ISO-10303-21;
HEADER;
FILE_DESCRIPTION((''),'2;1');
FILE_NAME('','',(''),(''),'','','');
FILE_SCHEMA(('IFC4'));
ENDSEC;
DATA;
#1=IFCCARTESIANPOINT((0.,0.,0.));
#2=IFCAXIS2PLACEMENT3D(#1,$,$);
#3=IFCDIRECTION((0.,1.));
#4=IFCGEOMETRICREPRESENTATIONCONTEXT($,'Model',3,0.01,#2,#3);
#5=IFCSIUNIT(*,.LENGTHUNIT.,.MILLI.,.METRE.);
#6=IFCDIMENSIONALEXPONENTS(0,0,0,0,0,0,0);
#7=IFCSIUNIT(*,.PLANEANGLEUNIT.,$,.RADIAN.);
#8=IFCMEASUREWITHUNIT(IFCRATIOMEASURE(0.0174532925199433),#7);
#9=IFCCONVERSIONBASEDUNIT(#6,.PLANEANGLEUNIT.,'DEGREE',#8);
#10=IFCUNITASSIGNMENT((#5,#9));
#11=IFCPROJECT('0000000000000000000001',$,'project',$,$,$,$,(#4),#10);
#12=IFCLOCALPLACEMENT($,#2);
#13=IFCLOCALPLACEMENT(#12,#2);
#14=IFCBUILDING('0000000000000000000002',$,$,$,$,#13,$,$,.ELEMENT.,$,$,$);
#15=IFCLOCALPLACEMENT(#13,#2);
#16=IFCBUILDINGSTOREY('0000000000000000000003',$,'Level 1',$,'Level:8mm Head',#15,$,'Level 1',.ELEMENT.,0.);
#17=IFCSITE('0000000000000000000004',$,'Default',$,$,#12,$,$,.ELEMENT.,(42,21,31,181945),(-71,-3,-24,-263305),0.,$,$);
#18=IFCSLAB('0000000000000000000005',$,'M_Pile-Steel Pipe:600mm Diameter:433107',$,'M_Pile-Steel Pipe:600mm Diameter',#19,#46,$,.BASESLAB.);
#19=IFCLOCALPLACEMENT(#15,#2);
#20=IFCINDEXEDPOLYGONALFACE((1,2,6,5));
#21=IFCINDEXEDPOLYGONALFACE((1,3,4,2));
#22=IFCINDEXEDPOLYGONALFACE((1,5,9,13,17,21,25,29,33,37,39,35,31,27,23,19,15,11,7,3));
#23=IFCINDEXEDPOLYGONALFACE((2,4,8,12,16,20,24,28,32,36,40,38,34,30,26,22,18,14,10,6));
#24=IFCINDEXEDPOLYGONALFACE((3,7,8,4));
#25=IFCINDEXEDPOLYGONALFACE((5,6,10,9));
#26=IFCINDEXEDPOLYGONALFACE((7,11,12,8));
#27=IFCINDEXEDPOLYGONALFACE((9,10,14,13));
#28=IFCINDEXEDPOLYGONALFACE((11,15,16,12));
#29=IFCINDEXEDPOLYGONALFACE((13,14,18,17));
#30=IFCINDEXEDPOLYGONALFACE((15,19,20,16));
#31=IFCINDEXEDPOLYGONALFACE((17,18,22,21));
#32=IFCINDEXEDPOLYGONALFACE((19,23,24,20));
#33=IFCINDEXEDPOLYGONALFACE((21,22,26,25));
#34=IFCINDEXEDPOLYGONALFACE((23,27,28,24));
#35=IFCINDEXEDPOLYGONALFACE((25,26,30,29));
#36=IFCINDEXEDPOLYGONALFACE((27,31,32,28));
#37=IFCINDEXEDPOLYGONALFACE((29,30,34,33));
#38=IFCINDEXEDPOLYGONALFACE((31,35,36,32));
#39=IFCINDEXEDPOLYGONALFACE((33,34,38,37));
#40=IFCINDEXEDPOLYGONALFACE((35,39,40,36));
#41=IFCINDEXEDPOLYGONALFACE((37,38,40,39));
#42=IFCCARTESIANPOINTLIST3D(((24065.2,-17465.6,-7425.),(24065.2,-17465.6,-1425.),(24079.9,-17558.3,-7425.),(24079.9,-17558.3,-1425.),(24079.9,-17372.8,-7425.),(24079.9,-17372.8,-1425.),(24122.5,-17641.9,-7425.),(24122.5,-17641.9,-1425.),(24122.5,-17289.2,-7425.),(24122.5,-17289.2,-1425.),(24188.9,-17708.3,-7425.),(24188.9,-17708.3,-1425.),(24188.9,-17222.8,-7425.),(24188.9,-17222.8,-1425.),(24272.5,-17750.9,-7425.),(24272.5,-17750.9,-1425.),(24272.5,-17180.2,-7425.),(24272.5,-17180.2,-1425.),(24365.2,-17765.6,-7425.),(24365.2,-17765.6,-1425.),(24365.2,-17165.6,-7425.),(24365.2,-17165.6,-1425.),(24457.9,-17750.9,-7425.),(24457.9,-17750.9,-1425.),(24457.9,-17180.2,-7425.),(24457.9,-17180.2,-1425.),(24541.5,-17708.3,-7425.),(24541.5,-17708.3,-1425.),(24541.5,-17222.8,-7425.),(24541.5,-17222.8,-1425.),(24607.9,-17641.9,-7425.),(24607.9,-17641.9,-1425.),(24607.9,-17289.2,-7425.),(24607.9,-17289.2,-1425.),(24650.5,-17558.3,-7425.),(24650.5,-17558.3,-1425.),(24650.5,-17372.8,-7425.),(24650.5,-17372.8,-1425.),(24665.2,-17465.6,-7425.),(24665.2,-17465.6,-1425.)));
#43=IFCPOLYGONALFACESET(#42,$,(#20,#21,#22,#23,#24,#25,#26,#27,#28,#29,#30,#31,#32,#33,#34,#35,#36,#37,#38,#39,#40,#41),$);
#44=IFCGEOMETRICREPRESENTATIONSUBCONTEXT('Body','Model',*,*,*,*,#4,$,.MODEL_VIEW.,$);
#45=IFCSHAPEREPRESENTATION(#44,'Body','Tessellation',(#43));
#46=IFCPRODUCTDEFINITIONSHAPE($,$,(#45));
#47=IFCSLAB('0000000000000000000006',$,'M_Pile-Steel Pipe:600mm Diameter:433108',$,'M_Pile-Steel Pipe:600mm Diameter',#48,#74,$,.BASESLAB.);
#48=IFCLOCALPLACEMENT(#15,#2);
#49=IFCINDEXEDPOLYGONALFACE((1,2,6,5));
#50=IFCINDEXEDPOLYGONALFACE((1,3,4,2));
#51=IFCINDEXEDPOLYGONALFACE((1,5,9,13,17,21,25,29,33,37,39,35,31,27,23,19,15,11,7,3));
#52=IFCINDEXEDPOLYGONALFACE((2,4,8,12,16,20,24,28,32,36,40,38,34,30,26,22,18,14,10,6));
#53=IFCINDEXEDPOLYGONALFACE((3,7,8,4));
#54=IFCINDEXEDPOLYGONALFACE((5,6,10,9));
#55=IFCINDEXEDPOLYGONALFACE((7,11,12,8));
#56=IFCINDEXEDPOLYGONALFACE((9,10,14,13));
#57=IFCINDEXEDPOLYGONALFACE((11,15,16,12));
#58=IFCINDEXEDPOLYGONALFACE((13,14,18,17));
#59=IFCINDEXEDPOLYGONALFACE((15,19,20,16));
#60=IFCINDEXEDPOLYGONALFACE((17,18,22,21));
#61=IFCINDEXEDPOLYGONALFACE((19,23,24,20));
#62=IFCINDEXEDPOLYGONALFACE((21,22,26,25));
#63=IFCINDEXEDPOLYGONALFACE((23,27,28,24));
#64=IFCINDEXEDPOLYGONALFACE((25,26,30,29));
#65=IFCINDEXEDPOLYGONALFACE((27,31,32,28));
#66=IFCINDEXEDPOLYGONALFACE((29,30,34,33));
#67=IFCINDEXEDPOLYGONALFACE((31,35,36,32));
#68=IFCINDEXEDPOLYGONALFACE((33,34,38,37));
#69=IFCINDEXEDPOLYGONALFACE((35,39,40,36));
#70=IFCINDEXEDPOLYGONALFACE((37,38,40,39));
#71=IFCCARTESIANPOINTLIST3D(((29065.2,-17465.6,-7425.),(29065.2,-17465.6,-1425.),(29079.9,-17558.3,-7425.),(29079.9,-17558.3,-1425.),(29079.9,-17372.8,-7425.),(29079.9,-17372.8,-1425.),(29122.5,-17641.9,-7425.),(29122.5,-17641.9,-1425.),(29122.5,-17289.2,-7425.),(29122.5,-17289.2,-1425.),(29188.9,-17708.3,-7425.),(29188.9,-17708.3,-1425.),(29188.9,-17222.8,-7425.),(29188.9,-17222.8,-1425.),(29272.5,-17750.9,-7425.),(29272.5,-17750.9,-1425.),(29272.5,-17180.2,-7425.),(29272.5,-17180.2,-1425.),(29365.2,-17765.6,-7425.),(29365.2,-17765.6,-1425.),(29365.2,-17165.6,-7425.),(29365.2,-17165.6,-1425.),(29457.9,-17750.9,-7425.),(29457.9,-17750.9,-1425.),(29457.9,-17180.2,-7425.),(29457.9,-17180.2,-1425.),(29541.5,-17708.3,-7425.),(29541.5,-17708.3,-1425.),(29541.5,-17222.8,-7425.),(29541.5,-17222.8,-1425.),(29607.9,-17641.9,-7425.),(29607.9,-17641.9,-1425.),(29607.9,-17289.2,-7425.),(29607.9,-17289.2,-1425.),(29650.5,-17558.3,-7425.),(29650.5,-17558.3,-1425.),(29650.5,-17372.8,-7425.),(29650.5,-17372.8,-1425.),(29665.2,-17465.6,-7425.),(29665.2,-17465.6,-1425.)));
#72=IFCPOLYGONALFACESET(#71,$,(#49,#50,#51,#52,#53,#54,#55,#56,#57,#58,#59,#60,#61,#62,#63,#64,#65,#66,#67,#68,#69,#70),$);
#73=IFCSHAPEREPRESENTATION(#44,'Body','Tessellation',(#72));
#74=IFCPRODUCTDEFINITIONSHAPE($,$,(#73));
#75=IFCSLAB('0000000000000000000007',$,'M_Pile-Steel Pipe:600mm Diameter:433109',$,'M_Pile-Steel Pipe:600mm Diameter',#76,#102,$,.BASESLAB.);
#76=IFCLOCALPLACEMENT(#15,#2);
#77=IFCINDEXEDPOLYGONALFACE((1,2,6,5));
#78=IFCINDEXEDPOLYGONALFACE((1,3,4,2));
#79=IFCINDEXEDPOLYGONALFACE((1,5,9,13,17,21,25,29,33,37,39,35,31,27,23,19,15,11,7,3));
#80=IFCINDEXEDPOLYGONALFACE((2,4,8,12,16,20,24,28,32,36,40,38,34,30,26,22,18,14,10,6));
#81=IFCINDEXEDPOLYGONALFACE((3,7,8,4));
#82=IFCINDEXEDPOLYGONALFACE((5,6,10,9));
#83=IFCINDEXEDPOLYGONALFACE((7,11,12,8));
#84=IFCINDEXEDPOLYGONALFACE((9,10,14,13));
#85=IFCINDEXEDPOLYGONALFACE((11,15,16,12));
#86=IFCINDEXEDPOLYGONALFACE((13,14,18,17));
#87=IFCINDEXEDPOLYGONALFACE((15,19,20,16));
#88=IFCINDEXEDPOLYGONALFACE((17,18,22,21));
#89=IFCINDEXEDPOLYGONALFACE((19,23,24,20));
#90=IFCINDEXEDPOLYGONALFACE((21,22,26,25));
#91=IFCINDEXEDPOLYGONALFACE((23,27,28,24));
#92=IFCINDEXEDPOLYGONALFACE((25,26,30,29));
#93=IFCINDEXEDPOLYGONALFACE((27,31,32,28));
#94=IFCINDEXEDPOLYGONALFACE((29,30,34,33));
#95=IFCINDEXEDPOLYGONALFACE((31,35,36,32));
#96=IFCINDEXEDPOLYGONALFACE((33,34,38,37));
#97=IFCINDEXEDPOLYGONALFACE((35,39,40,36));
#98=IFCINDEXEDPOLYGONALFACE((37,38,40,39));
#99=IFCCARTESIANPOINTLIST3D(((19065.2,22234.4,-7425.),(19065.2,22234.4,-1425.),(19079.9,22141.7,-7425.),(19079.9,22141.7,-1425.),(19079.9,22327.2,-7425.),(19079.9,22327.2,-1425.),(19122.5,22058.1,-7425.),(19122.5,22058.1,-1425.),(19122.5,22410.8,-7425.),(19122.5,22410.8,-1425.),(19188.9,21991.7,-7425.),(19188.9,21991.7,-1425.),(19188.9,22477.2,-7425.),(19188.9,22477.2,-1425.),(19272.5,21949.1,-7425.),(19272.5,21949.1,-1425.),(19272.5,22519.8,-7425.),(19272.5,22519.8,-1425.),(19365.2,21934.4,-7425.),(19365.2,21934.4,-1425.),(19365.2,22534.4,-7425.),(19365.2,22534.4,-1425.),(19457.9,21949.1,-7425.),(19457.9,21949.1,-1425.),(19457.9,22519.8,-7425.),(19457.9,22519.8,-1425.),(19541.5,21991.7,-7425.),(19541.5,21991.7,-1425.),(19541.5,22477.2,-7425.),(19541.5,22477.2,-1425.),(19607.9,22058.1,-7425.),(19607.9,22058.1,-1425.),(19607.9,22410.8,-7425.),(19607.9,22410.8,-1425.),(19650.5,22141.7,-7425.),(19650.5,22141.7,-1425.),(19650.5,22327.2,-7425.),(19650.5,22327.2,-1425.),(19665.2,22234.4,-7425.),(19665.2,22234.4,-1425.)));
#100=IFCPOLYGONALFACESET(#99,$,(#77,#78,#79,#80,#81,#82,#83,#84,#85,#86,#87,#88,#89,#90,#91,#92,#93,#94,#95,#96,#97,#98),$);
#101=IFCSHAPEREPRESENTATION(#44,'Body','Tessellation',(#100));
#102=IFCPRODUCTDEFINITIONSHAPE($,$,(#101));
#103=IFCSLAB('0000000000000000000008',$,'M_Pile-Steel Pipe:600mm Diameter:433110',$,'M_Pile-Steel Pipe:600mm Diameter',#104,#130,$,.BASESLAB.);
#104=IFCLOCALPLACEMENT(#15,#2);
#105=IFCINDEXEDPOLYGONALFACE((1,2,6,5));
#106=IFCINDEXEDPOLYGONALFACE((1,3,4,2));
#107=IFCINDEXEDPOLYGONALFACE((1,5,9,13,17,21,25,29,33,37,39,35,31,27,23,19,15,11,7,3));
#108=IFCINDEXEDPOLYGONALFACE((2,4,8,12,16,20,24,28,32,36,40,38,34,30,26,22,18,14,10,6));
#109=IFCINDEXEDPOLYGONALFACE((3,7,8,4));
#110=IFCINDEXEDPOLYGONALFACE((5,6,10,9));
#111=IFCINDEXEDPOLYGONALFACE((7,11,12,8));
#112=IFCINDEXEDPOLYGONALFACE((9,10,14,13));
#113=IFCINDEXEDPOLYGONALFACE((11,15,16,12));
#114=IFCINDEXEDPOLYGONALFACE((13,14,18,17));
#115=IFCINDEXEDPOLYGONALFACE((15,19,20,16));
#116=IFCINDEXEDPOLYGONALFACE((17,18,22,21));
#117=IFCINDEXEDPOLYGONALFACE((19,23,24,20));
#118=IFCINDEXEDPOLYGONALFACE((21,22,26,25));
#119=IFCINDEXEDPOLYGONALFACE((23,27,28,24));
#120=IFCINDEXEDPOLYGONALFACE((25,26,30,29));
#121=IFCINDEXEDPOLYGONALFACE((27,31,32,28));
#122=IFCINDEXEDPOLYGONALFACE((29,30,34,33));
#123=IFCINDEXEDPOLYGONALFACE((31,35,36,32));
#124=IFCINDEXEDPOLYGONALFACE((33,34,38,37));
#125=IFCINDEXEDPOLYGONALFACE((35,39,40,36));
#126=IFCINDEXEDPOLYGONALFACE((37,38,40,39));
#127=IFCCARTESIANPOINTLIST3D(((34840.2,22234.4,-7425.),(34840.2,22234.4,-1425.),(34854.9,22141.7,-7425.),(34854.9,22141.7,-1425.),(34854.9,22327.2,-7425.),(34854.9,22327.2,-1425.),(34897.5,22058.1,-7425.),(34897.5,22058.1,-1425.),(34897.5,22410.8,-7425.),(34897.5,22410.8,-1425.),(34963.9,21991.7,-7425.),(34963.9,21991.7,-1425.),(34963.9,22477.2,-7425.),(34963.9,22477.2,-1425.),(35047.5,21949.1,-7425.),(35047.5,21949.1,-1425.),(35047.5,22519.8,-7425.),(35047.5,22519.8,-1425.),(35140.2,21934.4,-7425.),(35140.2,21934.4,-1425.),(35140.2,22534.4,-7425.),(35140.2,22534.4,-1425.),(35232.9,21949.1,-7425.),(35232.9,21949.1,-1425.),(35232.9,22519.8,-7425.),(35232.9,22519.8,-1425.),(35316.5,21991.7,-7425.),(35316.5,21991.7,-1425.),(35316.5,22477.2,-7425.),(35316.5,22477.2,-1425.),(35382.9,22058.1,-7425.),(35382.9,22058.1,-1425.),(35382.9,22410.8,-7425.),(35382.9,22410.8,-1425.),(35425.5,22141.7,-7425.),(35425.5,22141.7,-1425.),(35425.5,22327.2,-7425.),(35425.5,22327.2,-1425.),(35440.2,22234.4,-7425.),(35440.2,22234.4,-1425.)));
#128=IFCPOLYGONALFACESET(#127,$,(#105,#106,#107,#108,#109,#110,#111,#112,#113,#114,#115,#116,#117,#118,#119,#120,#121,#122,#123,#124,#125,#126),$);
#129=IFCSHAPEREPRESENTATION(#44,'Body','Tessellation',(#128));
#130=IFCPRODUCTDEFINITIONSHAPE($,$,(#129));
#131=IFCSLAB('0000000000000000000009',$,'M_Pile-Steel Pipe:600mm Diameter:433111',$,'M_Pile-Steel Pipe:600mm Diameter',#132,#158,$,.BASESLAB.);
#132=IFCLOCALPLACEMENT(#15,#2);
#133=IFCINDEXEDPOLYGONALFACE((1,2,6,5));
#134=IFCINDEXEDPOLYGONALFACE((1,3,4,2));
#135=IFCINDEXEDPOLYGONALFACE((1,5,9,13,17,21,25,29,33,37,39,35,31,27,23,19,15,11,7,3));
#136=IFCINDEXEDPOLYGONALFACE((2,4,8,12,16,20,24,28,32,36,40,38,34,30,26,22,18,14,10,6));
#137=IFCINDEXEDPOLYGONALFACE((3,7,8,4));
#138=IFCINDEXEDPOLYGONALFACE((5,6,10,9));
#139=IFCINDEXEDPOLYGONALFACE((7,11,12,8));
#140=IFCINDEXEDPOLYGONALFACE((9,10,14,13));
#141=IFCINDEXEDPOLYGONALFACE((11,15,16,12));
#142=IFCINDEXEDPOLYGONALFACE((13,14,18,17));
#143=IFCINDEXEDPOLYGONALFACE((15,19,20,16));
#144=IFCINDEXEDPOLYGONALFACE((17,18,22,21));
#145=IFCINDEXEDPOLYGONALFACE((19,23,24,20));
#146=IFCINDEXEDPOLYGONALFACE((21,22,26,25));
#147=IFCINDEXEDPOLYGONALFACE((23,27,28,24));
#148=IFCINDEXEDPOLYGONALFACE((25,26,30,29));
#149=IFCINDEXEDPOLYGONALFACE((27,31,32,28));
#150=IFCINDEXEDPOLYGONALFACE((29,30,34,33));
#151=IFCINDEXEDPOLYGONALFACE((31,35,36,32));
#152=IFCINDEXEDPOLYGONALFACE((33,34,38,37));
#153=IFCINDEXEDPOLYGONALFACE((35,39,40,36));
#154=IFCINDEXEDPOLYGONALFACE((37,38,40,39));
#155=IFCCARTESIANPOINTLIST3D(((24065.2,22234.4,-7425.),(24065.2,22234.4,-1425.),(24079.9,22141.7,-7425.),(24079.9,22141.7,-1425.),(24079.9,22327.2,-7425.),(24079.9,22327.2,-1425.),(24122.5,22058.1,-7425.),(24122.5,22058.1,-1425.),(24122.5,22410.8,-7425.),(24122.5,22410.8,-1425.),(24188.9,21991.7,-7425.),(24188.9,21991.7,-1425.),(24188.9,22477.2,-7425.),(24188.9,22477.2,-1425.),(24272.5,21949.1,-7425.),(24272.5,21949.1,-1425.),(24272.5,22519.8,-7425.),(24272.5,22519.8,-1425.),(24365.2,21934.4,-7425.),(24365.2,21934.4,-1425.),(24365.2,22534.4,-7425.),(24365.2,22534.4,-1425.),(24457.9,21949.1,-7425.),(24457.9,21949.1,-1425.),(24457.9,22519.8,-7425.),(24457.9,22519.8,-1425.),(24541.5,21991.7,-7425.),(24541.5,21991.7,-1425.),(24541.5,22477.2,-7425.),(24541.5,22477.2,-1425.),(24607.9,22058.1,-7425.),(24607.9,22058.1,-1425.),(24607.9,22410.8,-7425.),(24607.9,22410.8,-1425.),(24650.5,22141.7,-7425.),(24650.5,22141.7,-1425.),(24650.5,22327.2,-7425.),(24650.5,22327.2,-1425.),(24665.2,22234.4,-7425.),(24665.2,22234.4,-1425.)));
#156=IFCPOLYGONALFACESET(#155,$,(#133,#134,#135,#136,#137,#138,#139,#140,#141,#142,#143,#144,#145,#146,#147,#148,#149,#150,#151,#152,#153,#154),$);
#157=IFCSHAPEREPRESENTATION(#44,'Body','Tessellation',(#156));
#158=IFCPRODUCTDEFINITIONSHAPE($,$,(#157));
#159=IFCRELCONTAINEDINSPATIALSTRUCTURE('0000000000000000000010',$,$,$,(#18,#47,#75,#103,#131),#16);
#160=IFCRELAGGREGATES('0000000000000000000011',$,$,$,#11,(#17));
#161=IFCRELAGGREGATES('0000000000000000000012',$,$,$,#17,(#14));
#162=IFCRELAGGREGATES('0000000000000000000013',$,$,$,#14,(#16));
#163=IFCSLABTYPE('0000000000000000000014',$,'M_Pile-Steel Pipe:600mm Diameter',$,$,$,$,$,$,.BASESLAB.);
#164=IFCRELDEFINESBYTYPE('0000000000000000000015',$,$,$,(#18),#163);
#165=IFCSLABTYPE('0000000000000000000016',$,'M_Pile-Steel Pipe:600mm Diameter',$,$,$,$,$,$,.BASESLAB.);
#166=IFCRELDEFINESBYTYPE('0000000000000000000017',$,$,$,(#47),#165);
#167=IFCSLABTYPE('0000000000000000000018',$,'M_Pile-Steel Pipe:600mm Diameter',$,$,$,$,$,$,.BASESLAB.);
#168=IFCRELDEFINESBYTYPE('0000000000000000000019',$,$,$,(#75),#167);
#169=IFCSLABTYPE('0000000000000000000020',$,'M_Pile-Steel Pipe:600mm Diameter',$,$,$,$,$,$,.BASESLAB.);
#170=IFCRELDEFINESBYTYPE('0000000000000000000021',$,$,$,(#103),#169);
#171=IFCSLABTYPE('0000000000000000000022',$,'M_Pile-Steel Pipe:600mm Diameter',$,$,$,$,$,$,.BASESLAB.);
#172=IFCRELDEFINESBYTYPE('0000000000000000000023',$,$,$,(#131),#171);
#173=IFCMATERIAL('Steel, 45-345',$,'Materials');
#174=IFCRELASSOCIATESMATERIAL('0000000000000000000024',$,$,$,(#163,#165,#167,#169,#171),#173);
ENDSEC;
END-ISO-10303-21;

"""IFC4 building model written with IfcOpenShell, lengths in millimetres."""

from ifc_helpers import new_model, entity, si_unit, converted_unit, direction, frame, origin, place, context, subcontext, project, spatial, indexed_curve, outline, extrude, material, type_object, element, save


model = new_model("IFC4")

# Units and contexts
model_context = context("Model", 3, precision=0.01, world=origin(), true_north=direction((0.0, 1.0)))
body_context = subcontext(model_context, "Body", "Model", "MODEL_VIEW")
ifc_project = project(units=[si_unit("LENGTHUNIT", "METRE", prefix="MILLI"), converted_unit("PLANEANGLEUNIT", "DEGREE", entity("IfcRatioMeasure", 0.0174532925199433), si_unit("PLANEANGLEUNIT", "RADIAN"), dimensions=[0, 0, 0, 0, 0, 0, 0])], contexts=[model_context])

# Site, building, storey
site_placement = place(None, origin())
site = spatial("IfcSite", under=ifc_project, at=site_placement, Name="Default", CompositionType="ELEMENT", RefLatitude=(42, 21, 31, 181945), RefLongitude=(-71, -3, -24, -263305), RefElevation=0.0)
building_placement = place(site_placement, origin())
building = spatial("IfcBuilding", under=site, at=building_placement, CompositionType="ELEMENT")
storey_placement = place(building_placement, origin())
storey = spatial("IfcBuildingStorey", under=building, at=storey_placement, Name="Level 1", ObjectType="Level:8mm Head", LongName="Level 1", CompositionType="ELEMENT", Elevation=0.0)

# Slabs
ifc_material_1 = material(Name="Steel, 45-345", Category="Materials")
slab_type_1 = type_object("IfcSlabType", Name="M_Pile-Steel Pipe:600mm Diameter", PredefinedType="BASESLAB", material=ifc_material_1)
slab_1_placement = place(building_placement, origin())
element("IfcSlab", 1, at=slab_1_placement, inside=storey, type_object=slab_type_1, Name="M_Pile-Steel Pipe:600mm Diameter:433107", ObjectType="M_Pile-Steel Pipe:600mm Diameter", PredefinedType="BASESLAB", context=body_context, shape_type="SweptSolid", body=[
    extrude(outline(indexed_curve([(300.0, 0.0), (285.3, 92.7), (242.7, 176.3), (176.3, 242.7), (92.7, 285.3), (0.0, 300.0), (-92.7, 285.3), (-176.3, 242.7), (-242.7, 176.3), (-285.3, 92.7), (-300.0, 0.0), (-285.3, -92.7), (-242.7, -176.3), (-176.3, -242.7), (-92.7, -285.3), (0.0, -300.0), (92.7, -285.3), (176.3, -242.7), (242.7, -176.3), (285.3, -92.7), (300.0, 0.0)], self_intersect=False)), frame((24365.2, -17465.6, -7425.0)), (0.0, 0.0, 1.0), 6000.0),
])
slab_type_2 = type_object("IfcSlabType", Name="M_Pile-Steel Pipe:600mm Diameter", PredefinedType="BASESLAB", material=ifc_material_1)
slab_2_placement = place(building_placement, origin())
element("IfcSlab", 2, at=slab_2_placement, inside=storey, type_object=slab_type_2, Name="M_Pile-Steel Pipe:600mm Diameter:433108", ObjectType="M_Pile-Steel Pipe:600mm Diameter", PredefinedType="BASESLAB", context=body_context, shape_type="SweptSolid", body=[
    extrude(outline(indexed_curve([(300.0, 0.0), (285.3, 92.7), (242.7, 176.3), (176.3, 242.7), (92.7, 285.3), (0.0, 300.0), (-92.7, 285.3), (-176.3, 242.7), (-242.7, 176.3), (-285.3, 92.7), (-300.0, 0.0), (-285.3, -92.7), (-242.7, -176.3), (-176.3, -242.7), (-92.7, -285.3), (0.0, -300.0), (92.7, -285.3), (176.3, -242.7), (242.7, -176.3), (285.3, -92.7), (300.0, 0.0)], self_intersect=False)), frame((29365.2, -17465.6, -7425.0)), (0.0, 0.0, 1.0), 6000.0),
])
slab_type_3 = type_object("IfcSlabType", Name="M_Pile-Steel Pipe:600mm Diameter", PredefinedType="BASESLAB", material=ifc_material_1)
slab_3_placement = place(building_placement, origin())
element("IfcSlab", 3, at=slab_3_placement, inside=storey, type_object=slab_type_3, Name="M_Pile-Steel Pipe:600mm Diameter:433109", ObjectType="M_Pile-Steel Pipe:600mm Diameter", PredefinedType="BASESLAB", context=body_context, shape_type="SweptSolid", body=[
    extrude(outline(indexed_curve([(300.0, 0.0), (285.3, 92.7), (242.7, 176.3), (176.3, 242.7), (92.7, 285.3), (0.0, 300.0), (-92.7, 285.3), (-176.3, 242.7), (-242.7, 176.3), (-285.3, 92.7), (-300.0, 0.0), (-285.3, -92.7), (-242.7, -176.3), (-176.3, -242.7), (-92.7, -285.3), (0.0, -300.0), (92.7, -285.3), (176.3, -242.7), (242.7, -176.3), (285.3, -92.7), (300.0, 0.0)], self_intersect=False)), frame((19365.2, 22234.4, -7425.0)), (0.0, 0.0, 1.0), 6000.0),
])
slab_type_4 = type_object("IfcSlabType", Name="M_Pile-Steel Pipe:600mm Diameter", PredefinedType="BASESLAB", material=ifc_material_1)
slab_4_placement = place(building_placement, origin())
element("IfcSlab", 4, at=slab_4_placement, inside=storey, type_object=slab_type_4, Name="M_Pile-Steel Pipe:600mm Diameter:433110", ObjectType="M_Pile-Steel Pipe:600mm Diameter", PredefinedType="BASESLAB", context=body_context, shape_type="SweptSolid", body=[
    extrude(outline(indexed_curve([(300.0, 0.0), (285.3, 92.7), (242.7, 176.3), (176.3, 242.7), (92.7, 285.3), (0.0, 300.0), (-92.7, 285.3), (-176.3, 242.7), (-242.7, 176.3), (-285.3, 92.7), (-300.0, 0.0), (-285.3, -92.7), (-242.7, -176.3), (-176.3, -242.7), (-92.7, -285.3), (0.0, -300.0), (92.7, -285.3), (176.3, -242.7), (242.7, -176.3), (285.3, -92.7), (300.0, 0.0)], self_intersect=False)), frame((35140.2, 22234.4, -7425.0)), (0.0, 0.0, 1.0), 6000.0),
])
slab_type_5 = type_object("IfcSlabType", Name="M_Pile-Steel Pipe:600mm Diameter", PredefinedType="BASESLAB", material=ifc_material_1)
slab_5_placement = place(building_placement, origin())
element("IfcSlab", 5, at=slab_5_placement, inside=storey, type_object=slab_type_5, Name="M_Pile-Steel Pipe:600mm Diameter:433111", ObjectType="M_Pile-Steel Pipe:600mm Diameter", PredefinedType="BASESLAB", context=body_context, shape_type="SweptSolid", body=[
    extrude(outline(indexed_curve([(300.0, 0.0), (285.3, 92.7), (242.7, 176.3), (176.3, 242.7), (92.7, 285.3), (0.0, 300.0), (-92.7, 285.3), (-176.3, 242.7), (-242.7, 176.3), (-285.3, 92.7), (-300.0, 0.0), (-285.3, -92.7), (-242.7, -176.3), (-176.3, -242.7), (-92.7, -285.3), (0.0, -300.0), (92.7, -285.3), (176.3, -242.7), (242.7, -176.3), (285.3, -92.7), (300.0, 0.0)], self_intersect=False)), frame((24365.2, 22234.4, -7425.0)), (0.0, 0.0, 1.0), 6000.0),
])

save(model, "model.ifc")
